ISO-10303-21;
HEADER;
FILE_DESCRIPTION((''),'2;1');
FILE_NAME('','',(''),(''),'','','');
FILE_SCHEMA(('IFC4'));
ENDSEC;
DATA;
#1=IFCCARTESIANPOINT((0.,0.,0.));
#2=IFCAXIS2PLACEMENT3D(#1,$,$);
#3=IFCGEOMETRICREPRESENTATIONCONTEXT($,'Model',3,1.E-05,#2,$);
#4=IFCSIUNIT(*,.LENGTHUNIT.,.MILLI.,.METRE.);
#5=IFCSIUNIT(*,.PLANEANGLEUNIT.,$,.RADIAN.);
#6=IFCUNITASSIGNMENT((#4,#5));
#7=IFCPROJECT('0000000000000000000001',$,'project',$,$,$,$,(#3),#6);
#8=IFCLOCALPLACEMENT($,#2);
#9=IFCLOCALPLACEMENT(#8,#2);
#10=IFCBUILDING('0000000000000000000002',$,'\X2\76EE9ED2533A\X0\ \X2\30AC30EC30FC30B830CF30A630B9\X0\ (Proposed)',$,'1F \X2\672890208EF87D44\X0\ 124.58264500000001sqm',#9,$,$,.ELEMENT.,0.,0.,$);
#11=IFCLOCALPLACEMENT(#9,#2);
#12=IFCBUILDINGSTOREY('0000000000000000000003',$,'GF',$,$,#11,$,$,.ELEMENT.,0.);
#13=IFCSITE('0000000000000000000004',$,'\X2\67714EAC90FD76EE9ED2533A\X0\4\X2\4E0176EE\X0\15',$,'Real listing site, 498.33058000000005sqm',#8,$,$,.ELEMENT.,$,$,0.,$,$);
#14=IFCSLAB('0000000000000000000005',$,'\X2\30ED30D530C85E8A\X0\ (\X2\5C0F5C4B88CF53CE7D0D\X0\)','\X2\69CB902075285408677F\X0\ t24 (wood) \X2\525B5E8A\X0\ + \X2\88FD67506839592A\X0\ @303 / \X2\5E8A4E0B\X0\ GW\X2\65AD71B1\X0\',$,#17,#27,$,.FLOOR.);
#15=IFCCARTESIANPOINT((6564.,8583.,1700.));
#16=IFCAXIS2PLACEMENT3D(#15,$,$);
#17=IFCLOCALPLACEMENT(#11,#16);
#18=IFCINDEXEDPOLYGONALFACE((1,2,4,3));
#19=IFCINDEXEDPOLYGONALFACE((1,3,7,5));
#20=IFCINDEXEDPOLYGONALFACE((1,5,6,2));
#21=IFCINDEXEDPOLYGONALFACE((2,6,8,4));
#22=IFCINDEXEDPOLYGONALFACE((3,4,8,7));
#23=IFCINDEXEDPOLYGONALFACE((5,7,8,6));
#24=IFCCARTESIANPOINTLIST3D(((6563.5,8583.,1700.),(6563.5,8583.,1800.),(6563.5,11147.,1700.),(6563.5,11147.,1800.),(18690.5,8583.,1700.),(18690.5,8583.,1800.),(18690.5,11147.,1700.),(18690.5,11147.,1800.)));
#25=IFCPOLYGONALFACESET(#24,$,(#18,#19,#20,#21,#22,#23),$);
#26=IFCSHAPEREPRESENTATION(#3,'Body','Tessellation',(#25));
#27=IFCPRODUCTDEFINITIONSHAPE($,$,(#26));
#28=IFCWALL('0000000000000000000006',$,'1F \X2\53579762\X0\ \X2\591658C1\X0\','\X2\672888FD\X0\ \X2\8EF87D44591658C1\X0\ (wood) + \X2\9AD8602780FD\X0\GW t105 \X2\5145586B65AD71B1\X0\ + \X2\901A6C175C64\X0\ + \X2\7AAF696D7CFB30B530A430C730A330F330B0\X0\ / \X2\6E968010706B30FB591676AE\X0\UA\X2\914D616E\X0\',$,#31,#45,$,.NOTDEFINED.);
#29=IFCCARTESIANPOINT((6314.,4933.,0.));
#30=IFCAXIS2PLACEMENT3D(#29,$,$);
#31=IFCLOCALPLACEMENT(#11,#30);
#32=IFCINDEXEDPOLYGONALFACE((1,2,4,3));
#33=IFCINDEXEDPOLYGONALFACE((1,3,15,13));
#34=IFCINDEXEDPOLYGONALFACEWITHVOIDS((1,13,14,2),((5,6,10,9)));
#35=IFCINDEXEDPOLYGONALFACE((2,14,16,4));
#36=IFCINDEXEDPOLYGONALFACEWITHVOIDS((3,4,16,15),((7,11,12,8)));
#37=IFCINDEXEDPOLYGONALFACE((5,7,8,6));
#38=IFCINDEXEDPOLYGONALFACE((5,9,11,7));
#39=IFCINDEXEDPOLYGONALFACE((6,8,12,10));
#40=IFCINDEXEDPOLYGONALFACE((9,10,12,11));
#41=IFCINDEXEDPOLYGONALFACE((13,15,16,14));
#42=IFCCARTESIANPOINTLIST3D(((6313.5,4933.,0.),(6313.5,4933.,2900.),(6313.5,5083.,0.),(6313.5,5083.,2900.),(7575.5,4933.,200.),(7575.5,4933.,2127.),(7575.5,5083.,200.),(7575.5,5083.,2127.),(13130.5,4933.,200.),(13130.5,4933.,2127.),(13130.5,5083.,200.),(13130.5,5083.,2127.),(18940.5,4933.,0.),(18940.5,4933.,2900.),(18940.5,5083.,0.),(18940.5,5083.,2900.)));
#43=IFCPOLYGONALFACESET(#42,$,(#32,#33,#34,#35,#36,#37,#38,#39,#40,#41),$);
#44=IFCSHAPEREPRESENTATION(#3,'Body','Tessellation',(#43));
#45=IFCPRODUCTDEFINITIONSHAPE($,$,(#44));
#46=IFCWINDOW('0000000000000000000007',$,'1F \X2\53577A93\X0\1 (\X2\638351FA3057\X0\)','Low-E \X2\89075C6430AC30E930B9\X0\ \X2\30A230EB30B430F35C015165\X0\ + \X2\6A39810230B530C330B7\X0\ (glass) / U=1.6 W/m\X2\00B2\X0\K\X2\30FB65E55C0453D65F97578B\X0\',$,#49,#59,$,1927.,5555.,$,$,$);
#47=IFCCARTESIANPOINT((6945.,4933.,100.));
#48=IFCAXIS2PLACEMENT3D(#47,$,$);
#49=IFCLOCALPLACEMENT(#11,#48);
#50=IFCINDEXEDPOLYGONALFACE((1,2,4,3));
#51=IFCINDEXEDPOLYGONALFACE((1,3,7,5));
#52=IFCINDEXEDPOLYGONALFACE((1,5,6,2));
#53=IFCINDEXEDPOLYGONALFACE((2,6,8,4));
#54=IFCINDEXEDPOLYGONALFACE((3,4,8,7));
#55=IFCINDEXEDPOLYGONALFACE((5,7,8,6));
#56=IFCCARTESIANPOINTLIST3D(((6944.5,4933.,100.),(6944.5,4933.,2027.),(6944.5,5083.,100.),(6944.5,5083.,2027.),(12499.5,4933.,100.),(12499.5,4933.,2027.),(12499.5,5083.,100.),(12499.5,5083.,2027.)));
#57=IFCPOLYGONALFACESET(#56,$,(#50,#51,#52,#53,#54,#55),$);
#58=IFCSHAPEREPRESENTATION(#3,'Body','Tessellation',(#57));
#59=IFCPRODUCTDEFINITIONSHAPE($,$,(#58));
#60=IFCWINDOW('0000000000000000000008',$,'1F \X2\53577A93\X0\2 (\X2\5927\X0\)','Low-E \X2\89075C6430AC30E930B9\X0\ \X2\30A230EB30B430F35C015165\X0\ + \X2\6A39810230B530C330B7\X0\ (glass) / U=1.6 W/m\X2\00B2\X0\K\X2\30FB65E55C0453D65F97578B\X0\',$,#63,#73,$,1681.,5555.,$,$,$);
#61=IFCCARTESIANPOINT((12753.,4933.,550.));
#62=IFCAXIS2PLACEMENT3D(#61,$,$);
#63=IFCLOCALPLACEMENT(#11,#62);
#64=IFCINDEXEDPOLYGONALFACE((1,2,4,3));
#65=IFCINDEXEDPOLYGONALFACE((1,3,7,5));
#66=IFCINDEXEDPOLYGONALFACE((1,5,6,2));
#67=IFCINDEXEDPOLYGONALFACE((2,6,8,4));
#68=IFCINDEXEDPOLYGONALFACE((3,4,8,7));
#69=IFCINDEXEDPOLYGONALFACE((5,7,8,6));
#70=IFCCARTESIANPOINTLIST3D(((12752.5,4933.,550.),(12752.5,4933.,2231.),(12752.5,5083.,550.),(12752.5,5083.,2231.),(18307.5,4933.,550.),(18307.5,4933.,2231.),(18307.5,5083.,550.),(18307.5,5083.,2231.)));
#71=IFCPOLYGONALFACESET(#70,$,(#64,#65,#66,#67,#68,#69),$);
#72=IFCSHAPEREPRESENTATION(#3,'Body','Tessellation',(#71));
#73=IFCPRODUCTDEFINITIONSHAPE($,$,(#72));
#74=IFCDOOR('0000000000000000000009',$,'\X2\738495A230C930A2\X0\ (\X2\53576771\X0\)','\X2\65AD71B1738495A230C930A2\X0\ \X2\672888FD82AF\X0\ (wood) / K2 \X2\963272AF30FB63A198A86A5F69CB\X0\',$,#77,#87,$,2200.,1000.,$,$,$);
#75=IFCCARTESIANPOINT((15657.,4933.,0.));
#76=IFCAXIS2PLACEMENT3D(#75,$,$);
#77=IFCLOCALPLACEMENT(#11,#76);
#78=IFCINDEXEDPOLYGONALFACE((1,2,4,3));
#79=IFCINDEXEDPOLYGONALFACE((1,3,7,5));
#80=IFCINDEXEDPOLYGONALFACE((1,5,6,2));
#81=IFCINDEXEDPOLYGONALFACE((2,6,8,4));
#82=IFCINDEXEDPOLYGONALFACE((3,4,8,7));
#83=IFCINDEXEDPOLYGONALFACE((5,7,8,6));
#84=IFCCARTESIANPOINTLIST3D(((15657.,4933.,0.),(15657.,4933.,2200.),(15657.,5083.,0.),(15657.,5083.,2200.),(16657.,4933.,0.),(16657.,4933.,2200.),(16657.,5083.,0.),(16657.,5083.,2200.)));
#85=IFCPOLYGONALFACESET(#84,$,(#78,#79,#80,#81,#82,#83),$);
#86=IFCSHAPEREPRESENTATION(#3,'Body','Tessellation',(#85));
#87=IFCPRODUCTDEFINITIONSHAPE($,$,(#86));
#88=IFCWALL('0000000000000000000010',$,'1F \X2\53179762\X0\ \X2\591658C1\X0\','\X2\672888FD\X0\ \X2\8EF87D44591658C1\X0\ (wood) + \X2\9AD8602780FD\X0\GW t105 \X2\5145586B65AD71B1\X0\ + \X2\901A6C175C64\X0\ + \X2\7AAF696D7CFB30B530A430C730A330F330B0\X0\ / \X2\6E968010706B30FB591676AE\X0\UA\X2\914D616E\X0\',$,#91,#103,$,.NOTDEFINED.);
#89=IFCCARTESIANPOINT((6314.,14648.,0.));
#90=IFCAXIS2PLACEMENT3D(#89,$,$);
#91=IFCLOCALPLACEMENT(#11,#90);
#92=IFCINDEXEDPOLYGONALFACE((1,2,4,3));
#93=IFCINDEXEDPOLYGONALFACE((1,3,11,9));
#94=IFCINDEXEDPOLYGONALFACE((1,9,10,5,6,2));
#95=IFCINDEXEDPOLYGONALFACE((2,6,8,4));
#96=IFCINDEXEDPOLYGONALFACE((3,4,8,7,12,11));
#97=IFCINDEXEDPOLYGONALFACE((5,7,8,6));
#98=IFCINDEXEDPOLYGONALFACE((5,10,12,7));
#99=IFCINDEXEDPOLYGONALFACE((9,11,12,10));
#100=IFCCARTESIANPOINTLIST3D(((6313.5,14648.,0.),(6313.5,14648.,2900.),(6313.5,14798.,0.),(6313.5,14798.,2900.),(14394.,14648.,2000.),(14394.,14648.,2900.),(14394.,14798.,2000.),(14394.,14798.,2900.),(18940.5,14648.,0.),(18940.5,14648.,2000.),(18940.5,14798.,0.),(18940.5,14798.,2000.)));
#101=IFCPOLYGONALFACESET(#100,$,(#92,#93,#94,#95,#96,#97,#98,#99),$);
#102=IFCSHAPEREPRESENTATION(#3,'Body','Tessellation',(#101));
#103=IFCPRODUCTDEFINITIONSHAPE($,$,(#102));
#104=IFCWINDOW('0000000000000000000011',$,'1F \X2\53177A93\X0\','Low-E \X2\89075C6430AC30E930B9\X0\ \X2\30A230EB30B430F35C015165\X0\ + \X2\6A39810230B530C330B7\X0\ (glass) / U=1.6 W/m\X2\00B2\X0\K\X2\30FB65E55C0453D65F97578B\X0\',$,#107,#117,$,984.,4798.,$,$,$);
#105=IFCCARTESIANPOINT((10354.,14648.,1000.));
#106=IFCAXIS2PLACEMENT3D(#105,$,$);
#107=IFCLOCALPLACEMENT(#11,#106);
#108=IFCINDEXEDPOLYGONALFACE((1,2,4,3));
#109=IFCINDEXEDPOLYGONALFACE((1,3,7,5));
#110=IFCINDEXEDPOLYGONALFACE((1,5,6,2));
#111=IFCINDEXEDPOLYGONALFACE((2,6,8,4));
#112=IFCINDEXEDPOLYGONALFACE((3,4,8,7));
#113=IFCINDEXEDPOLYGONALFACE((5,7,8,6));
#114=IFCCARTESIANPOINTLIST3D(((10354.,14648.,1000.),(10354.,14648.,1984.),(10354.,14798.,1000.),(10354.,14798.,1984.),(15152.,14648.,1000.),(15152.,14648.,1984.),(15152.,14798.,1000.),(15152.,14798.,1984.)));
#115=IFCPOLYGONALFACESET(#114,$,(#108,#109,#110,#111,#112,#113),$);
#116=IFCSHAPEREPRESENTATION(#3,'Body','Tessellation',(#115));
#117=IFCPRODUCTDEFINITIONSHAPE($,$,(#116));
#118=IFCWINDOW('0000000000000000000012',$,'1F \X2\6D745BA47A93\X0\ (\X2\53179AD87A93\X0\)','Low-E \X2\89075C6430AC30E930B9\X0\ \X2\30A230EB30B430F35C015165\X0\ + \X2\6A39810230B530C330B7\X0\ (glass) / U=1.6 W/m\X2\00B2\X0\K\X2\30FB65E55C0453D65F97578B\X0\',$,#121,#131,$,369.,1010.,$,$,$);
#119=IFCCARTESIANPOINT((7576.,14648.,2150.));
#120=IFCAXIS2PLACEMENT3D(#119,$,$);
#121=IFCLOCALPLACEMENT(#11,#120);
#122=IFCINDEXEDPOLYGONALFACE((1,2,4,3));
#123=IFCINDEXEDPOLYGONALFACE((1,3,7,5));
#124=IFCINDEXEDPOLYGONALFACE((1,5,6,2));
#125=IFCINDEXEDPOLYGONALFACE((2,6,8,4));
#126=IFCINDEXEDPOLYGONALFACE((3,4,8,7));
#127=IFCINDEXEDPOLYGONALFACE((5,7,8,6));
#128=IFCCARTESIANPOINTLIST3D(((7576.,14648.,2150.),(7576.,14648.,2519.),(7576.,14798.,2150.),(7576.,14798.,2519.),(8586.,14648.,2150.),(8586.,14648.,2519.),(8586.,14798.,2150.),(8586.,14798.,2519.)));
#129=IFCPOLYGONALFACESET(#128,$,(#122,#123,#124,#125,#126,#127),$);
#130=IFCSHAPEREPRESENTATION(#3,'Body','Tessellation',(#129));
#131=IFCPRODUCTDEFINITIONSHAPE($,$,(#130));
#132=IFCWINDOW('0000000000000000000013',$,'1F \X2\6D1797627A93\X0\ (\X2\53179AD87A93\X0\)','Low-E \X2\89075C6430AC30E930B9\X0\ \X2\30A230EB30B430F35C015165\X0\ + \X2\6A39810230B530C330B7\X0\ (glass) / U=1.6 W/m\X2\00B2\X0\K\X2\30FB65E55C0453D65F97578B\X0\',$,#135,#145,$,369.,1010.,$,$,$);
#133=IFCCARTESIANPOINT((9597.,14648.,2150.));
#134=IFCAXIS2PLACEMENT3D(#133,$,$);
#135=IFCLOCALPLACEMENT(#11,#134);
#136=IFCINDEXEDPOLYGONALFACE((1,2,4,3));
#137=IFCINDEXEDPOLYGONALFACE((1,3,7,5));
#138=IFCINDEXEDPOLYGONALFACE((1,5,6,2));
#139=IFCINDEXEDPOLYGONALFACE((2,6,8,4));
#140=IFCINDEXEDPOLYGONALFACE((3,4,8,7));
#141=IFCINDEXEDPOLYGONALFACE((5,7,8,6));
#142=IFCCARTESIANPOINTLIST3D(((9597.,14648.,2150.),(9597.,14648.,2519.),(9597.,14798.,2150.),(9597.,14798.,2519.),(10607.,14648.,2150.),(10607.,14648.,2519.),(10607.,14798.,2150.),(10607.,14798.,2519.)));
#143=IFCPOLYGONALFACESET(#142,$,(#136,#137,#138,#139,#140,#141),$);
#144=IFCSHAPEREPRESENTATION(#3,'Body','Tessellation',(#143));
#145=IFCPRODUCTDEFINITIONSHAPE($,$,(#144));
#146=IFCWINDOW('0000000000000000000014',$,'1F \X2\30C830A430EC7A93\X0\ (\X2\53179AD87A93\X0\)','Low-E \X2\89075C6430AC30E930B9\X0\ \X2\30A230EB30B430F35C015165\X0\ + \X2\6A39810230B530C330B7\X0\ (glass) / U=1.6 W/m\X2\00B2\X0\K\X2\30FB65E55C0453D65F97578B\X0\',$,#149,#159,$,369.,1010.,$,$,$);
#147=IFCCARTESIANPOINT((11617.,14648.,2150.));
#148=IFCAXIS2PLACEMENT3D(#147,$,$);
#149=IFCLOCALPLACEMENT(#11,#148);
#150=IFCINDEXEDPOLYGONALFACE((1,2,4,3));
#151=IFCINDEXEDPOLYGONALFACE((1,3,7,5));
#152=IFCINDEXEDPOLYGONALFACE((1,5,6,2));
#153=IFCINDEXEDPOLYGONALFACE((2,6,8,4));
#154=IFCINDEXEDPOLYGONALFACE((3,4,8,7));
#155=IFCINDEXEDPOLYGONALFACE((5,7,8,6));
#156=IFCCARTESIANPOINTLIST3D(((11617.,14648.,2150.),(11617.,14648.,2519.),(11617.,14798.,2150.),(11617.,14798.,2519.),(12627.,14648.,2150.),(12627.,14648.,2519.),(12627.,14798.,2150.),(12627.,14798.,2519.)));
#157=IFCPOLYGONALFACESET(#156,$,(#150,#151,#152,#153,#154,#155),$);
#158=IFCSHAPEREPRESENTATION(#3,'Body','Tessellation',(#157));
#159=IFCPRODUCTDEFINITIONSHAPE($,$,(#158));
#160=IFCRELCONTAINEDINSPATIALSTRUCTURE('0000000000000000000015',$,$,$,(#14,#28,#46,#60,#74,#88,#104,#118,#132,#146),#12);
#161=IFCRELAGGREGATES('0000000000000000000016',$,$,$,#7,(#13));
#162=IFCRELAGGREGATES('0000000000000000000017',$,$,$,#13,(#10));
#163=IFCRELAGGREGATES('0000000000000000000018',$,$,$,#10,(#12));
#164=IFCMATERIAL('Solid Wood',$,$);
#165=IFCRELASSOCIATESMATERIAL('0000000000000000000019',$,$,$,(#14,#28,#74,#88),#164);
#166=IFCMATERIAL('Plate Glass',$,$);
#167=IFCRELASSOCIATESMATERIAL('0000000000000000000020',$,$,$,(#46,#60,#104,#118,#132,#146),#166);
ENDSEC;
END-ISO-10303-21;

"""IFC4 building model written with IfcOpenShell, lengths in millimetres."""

from ifc_helpers import new_model, si_unit, frame, frame_2d, origin, place, context, project, spatial, rectangle, extrude, material, element, fill, save


model = new_model("IFC4")

# Units and contexts
model_context = context("Model", 3, precision=1e-05, world=origin())
ifc_project = project(units=[si_unit("LENGTHUNIT", "METRE", prefix="MILLI"), si_unit("PLANEANGLEUNIT", "RADIAN")], contexts=[model_context])

# Site, building, storey
site_placement = place(None, origin())
site = spatial("IfcSite", under=ifc_project, at=site_placement, Name="東京都目黒区4丁目15", ObjectType="Real listing site, 498.33058000000005sqm", CompositionType="ELEMENT", RefElevation=0.0)
building_placement = place(site_placement, origin())
building = spatial("IfcBuilding", under=site, at=building_placement, Name="目黒区 ガレージハウス (Proposed)", ObjectType="1F 木造軸組 124.58264500000001sqm", CompositionType="ELEMENT", ElevationOfRefHeight=0.0, ElevationOfTerrain=0.0)
storey_placement = place(building_placement, origin())
storey = spatial("IfcBuildingStorey", under=building, at=storey_placement, Name="GF", CompositionType="ELEMENT", Elevation=0.0)

# Slab
ifc_material_1 = material(Name="Solid Wood")
slab_1_placement = place(storey_placement, frame((6564.0, 8583.0, 1700.0)))
element("IfcSlab", 1, at=slab_1_placement, inside=storey, material=ifc_material_1, Name="ロフト床 (小屋裏収納)", Description="構造用合板 t24 (wood) 剛床 + 製材根太 @303 / 床下 GW断熱", PredefinedType="FLOOR", context=model_context, shape_type="SweptSolid", body=[
    extrude(rectangle(XDim=12127.0, YDim=2564.0, at=frame_2d((6063.0, 1282.0))), frame((6564.0, 8583.0, 1700.0)), (0.0, 0.0, 1.0), 100.0),
])

# Wall, openings, windows, door
wall_1_placement = place(storey_placement, frame((6314.0, 4933.0, 0.0)))
wall_1 = element("IfcWall", 2, at=wall_1_placement, inside=storey, material=ifc_material_1, Name="1F 南面 外壁", Description="木製 軸組外壁 (wood) + 高性能GW t105 充填断熱 + 通気層 + 窯業系サイディング / 準耐火・外皮UA配慮", PredefinedType="NOTDEFINED", context=model_context, shape_type="SweptSolid", body=[
    extrude(rectangle(XDim=12627.0, YDim=150.0, at=frame_2d((6313.0, 75.0))), frame((6314.0, 4933.0, 0.0)), (0.0, 0.0, 1.0), 2900.0),
])
opening_1_placement = place(storey_placement, frame((6945.0, 4933.0, 100.0)))
opening_1 = element("IfcOpeningElement", 3, at=opening_1_placement, cuts=wall_1, PredefinedType="NOTDEFINED", context=model_context, shape_type="SweptSolid", body=[
    extrude(rectangle(XDim=5555.0, YDim=150.0, at=frame_2d((2777.0, 75.0))), frame((6945.0, 4933.0, 100.0)), (0.0, 0.0, 1.0), 1927.0),
])
opening_2_placement = place(storey_placement, frame((12753.0, 4933.0, 550.0)))
opening_2 = element("IfcOpeningElement", 4, at=opening_2_placement, cuts=wall_1, PredefinedType="NOTDEFINED", context=model_context, shape_type="SweptSolid", body=[
    extrude(rectangle(XDim=5555.0, YDim=150.0, at=frame_2d((2777.0, 75.0))), frame((12753.0, 4933.0, 550.0)), (0.0, 0.0, 1.0), 1681.0),
])
opening_3_placement = place(storey_placement, frame((15657.0, 4933.0, 0.0)))
opening_3 = element("IfcOpeningElement", 5, at=opening_3_placement, cuts=wall_1, PredefinedType="NOTDEFINED", context=model_context, shape_type="SweptSolid", body=[
    extrude(rectangle(XDim=1000.0, YDim=150.0, at=frame_2d((500.0, 75.0))), frame((15657.0, 4933.0, 0.0)), (0.0, 0.0, 1.0), 2200.0),
])
ifc_material_2 = material(Name="Plate Glass")
window_1_placement = place(storey_placement, frame((6945.0, 4933.0, 100.0)))
window_1 = element("IfcWindow", 6, at=window_1_placement, inside=storey, material=ifc_material_2, Name="1F 南窓1 (掃出し)", Description="Low-E 複層ガラス アルゴン封入 + 樹脂サッシ (glass) / U=1.6 W/m²K・日射取得型", OverallHeight=1927.0, OverallWidth=5555.0, context=model_context, shape_type="SweptSolid", body=[
    extrude(rectangle(XDim=5555.0, YDim=150.0, at=frame_2d((2777.0, 75.0))), frame((6945.0, 4933.0, 100.0)), (0.0, 0.0, 1.0), 1927.0),
])
fill(opening_1, window_1)
window_2_placement = place(storey_placement, frame((12753.0, 4933.0, 550.0)))
window_2 = element("IfcWindow", 7, at=window_2_placement, inside=storey, material=ifc_material_2, Name="1F 南窓2 (大)", Description="Low-E 複層ガラス アルゴン封入 + 樹脂サッシ (glass) / U=1.6 W/m²K・日射取得型", OverallHeight=1681.0, OverallWidth=5555.0, context=model_context, shape_type="SweptSolid", body=[
    extrude(rectangle(XDim=5555.0, YDim=150.0, at=frame_2d((2777.0, 75.0))), frame((12753.0, 4933.0, 550.0)), (0.0, 0.0, 1.0), 1681.0),
])
fill(opening_2, window_2)
door_1_placement = place(storey_placement, frame((15657.0, 4933.0, 0.0)))
door_1 = element("IfcDoor", 8, at=door_1_placement, inside=storey, material=ifc_material_1, Name="玄関ドア (南東)", Description="断熱玄関ドア 木製芯 (wood) / K2 防犯・採風機構", OverallHeight=2200.0, OverallWidth=1000.0, context=model_context, shape_type="SweptSolid", body=[
    extrude(rectangle(XDim=1000.0, YDim=150.0, at=frame_2d((500.0, 75.0))), frame((15657.0, 4933.0, 0.0)), (0.0, 0.0, 1.0), 2200.0),
])
fill(opening_3, door_1)

# Wall, openings, windows
wall_2_placement = place(storey_placement, frame((6314.0, 14648.0, 0.0)))
wall_2 = element("IfcWall", 9, at=wall_2_placement, inside=storey, material=ifc_material_1, Name="1F 北面 外壁", Description="木製 軸組外壁 (wood) + 高性能GW t105 充填断熱 + 通気層 + 窯業系サイディング / 準耐火・外皮UA配慮", PredefinedType="NOTDEFINED", context=model_context, shape_type="SweptSolid", body=[
    extrude(rectangle(XDim=12627.0, YDim=150.0, at=frame_2d((6313.0, 75.0))), frame((6314.0, 14648.0, 0.0)), (0.0, 0.0, 1.0), 2900.0),
])
opening_4_placement = place(storey_placement, frame((10354.0, 14648.0, 1000.0)))
opening_4 = element("IfcOpeningElement", 10, at=opening_4_placement, cuts=wall_2, PredefinedType="NOTDEFINED", context=model_context, shape_type="SweptSolid", body=[
    extrude(rectangle(XDim=4798.0, YDim=150.0, at=frame_2d((2399.0, 75.0))), frame((10354.0, 14648.0, 1000.0)), (0.0, 0.0, 1.0), 984.0),
])
opening_5_placement = place(storey_placement, frame((7576.0, 14648.0, 2150.0)))
opening_5 = element("IfcOpeningElement", 11, at=opening_5_placement, cuts=wall_2, PredefinedType="NOTDEFINED", context=model_context, shape_type="SweptSolid", body=[
    extrude(rectangle(XDim=1010.0, YDim=150.0, at=frame_2d((505.0, 75.0))), frame((7576.0, 14648.0, 2150.0)), (0.0, 0.0, 1.0), 369.0),
])
opening_6_placement = place(storey_placement, frame((9597.0, 14648.0, 2150.0)))
opening_6 = element("IfcOpeningElement", 12, at=opening_6_placement, cuts=wall_2, PredefinedType="NOTDEFINED", context=model_context, shape_type="SweptSolid", body=[
    extrude(rectangle(XDim=1010.0, YDim=150.0, at=frame_2d((505.0, 75.0))), frame((9597.0, 14648.0, 2150.0)), (0.0, 0.0, 1.0), 369.0),
])
opening_7_placement = place(storey_placement, frame((11617.0, 14648.0, 2150.0)))
opening_7 = element("IfcOpeningElement", 13, at=opening_7_placement, cuts=wall_2, PredefinedType="NOTDEFINED", context=model_context, shape_type="SweptSolid", body=[
    extrude(rectangle(XDim=1010.0, YDim=150.0, at=frame_2d((505.0, 75.0))), frame((11617.0, 14648.0, 2150.0)), (0.0, 0.0, 1.0), 369.0),
])
window_3_placement = place(storey_placement, frame((10354.0, 14648.0, 1000.0)))
window_3 = element("IfcWindow", 14, at=window_3_placement, inside=storey, material=ifc_material_2, Name="1F 北窓", Description="Low-E 複層ガラス アルゴン封入 + 樹脂サッシ (glass) / U=1.6 W/m²K・日射取得型", OverallHeight=984.0, OverallWidth=4798.0, context=model_context, shape_type="SweptSolid", body=[
    extrude(rectangle(XDim=4798.0, YDim=150.0, at=frame_2d((2399.0, 75.0))), frame((10354.0, 14648.0, 1000.0)), (0.0, 0.0, 1.0), 984.0),
])
fill(opening_4, window_3)
window_4_placement = place(storey_placement, frame((7576.0, 14648.0, 2150.0)))
window_4 = element("IfcWindow", 15, at=window_4_placement, inside=storey, material=ifc_material_2, Name="1F 浴室窓 (北高窓)", Description="Low-E 複層ガラス アルゴン封入 + 樹脂サッシ (glass) / U=1.6 W/m²K・日射取得型", OverallHeight=369.0, OverallWidth=1010.0, context=model_context, shape_type="SweptSolid", body=[
    extrude(rectangle(XDim=1010.0, YDim=150.0, at=frame_2d((505.0, 75.0))), frame((7576.0, 14648.0, 2150.0)), (0.0, 0.0, 1.0), 369.0),
])
fill(opening_5, window_4)
window_5_placement = place(storey_placement, frame((9597.0, 14648.0, 2150.0)))
window_5 = element("IfcWindow", 16, at=window_5_placement, inside=storey, material=ifc_material_2, Name="1F 洗面窓 (北高窓)", Description="Low-E 複層ガラス アルゴン封入 + 樹脂サッシ (glass) / U=1.6 W/m²K・日射取得型", OverallHeight=369.0, OverallWidth=1010.0, context=model_context, shape_type="SweptSolid", body=[
    extrude(rectangle(XDim=1010.0, YDim=150.0, at=frame_2d((505.0, 75.0))), frame((9597.0, 14648.0, 2150.0)), (0.0, 0.0, 1.0), 369.0),
])
fill(opening_6, window_5)
window_6_placement = place(storey_placement, frame((11617.0, 14648.0, 2150.0)))
window_6 = element("IfcWindow", 17, at=window_6_placement, inside=storey, material=ifc_material_2, Name="1F トイレ窓 (北高窓)", Description="Low-E 複層ガラス アルゴン封入 + 樹脂サッシ (glass) / U=1.6 W/m²K・日射取得型", OverallHeight=369.0, OverallWidth=1010.0, context=model_context, shape_type="SweptSolid", body=[
    extrude(rectangle(XDim=1010.0, YDim=150.0, at=frame_2d((505.0, 75.0))), frame((11617.0, 14648.0, 2150.0)), (0.0, 0.0, 1.0), 369.0),
])
fill(opening_7, window_6)

save(model, "model.ifc")
